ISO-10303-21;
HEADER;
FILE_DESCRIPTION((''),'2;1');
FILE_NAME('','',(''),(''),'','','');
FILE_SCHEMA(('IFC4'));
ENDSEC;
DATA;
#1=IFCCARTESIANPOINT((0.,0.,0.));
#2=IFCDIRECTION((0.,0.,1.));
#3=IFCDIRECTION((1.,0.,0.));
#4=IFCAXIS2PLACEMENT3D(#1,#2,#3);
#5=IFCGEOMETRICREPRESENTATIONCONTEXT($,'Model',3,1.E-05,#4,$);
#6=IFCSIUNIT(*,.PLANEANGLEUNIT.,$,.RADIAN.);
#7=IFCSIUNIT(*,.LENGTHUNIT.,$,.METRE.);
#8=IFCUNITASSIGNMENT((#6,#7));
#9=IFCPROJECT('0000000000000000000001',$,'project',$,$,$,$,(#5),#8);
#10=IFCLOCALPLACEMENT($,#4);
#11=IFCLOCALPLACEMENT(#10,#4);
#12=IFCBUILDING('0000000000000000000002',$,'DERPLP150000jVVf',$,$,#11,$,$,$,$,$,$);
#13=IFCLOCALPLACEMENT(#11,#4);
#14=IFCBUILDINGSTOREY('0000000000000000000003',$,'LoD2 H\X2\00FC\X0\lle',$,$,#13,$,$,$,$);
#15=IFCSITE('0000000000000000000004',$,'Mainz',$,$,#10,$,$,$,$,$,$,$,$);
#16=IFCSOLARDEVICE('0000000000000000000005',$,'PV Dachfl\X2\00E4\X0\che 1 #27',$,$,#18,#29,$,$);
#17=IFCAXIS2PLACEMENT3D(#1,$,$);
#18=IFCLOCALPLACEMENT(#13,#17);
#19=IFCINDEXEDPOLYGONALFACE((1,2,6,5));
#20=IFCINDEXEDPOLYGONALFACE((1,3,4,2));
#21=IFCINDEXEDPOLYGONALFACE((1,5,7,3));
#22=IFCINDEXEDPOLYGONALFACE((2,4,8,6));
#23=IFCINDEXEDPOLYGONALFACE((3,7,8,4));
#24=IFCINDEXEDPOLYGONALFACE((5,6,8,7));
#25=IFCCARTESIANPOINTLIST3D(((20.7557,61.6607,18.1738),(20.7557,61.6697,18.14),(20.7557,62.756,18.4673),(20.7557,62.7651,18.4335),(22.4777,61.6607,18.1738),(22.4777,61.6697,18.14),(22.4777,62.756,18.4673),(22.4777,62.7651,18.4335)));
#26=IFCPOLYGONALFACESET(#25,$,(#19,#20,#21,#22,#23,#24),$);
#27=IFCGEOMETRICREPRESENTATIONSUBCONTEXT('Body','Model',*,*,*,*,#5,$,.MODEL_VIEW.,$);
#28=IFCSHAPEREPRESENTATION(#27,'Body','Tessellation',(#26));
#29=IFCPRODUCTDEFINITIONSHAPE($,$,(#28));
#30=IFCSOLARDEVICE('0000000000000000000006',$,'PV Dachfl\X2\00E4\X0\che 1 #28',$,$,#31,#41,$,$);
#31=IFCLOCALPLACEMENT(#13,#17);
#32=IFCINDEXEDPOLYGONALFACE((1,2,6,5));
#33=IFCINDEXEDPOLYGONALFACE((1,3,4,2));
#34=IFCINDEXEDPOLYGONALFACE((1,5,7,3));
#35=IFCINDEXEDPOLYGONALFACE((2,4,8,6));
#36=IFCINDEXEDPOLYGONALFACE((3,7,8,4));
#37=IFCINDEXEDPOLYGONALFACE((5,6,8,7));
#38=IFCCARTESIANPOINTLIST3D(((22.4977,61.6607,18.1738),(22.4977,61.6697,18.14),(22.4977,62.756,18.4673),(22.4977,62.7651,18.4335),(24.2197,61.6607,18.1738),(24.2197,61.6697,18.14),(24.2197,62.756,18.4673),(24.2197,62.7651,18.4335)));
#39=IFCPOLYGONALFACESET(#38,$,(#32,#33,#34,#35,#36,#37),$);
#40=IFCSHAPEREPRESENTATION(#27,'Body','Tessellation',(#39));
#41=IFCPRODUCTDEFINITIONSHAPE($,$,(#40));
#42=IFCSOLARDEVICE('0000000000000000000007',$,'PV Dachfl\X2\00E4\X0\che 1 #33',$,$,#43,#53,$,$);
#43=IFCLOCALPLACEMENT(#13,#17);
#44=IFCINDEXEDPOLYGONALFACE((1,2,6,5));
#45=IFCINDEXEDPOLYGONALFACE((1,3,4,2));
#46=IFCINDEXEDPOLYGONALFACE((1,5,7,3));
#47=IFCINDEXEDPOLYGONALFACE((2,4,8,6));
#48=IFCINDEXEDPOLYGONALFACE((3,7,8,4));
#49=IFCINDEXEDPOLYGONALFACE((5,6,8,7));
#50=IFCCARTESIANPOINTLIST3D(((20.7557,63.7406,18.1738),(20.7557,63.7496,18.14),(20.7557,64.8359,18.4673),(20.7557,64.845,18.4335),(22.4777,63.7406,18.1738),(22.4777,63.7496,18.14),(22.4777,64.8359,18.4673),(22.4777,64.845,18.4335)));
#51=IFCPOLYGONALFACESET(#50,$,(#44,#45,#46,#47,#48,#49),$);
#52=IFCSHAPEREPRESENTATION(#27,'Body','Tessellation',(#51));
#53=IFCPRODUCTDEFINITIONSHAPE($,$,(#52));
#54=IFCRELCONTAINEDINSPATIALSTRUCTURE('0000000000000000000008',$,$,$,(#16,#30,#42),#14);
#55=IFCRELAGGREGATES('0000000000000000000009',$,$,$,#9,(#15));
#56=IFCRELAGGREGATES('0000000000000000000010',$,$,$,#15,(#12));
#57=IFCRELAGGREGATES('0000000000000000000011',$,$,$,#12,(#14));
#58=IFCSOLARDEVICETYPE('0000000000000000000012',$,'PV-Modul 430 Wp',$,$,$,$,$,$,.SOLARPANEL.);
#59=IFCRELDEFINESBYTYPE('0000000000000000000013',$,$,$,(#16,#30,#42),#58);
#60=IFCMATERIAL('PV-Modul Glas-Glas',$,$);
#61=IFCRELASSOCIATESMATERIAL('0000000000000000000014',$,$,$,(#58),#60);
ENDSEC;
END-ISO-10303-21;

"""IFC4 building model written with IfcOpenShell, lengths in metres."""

from ifc_helpers import new_model, si_unit, frame, frame_2d, origin, origin_with_axes, place, context, subcontext, project, spatial, rectangle, extrude, source, transform, mapped, material, type_object, type_shapes, element, save


model = new_model("IFC4")

# Units and contexts
model_context = context("Model", 3, precision=1e-05, world=origin_with_axes())
body_context = subcontext(model_context, "Body", "Model", "MODEL_VIEW")
ifc_project = project(units=[si_unit("PLANEANGLEUNIT", "RADIAN"), si_unit("LENGTHUNIT", "METRE")], contexts=[model_context])

# Site, building, storey
site_placement = place(None, origin_with_axes())
site = spatial("IfcSite", under=ifc_project, at=site_placement, Name="Mainz")
building_placement = place(site_placement, origin_with_axes())
building = spatial("IfcBuilding", under=site, at=building_placement, Name="DERPLP150000jVVf")
storey_placement = place(building_placement, origin_with_axes())
storey = spatial("IfcBuildingStorey", under=building, at=storey_placement, Name="LoD2 Hülle")

# Solar devices
ifc_material = material(Name="PV-Modul Glas-Glas")
solar_device_type = type_object("IfcSolarDeviceType", Name="PV-Modul 430 Wp", PredefinedType="SOLARPANEL", material=ifc_material)
shared_shape = source(origin_with_axes(), body_context, "Body", "SweptSolid", [
    extrude(rectangle(XDim=1.722, YDim=1.134, at=frame_2d((0.861, 0.567))), origin(), (0.0, 0.0, 1.0), 0.035),
])
type_shapes(solar_device_type, [shared_shape])
for number, where, z_axis, x_axis, name in (
    (1, (20.7557, 61.6697, 18.14), (0.0, -0.258819, 0.965926), (1.0, 0.0, 0.0), "PV Dachfläche 1 #27"),
    (2, (22.4977, 61.6697, 18.14), (0.0, -0.258819, 0.965926), (1.0, 0.0, 0.0), "PV Dachfläche 1 #28"),
    (3, (20.7557, 63.7496, 18.14), (0.0, -0.258819, 0.965926), (1.0, 0.0, 0.0), "PV Dachfläche 1 #33"),
):
    element("IfcSolarDevice", number, at=place(storey_placement, frame(where, z_axis=z_axis, x_axis=x_axis)), inside=storey, type_object=solar_device_type, Name=name, context=body_context, shape_type="MappedRepresentation", body=[
        mapped(shared_shape, transform((0.0, 0.0, 0.0), x_axis=(1.0, 0.0, 0.0), y_axis=(0.0, 1.0, 0.0), z_axis=(0.0, 0.0, 1.0), scale=1.0)),
    ])

save(model, "model.ifc")
